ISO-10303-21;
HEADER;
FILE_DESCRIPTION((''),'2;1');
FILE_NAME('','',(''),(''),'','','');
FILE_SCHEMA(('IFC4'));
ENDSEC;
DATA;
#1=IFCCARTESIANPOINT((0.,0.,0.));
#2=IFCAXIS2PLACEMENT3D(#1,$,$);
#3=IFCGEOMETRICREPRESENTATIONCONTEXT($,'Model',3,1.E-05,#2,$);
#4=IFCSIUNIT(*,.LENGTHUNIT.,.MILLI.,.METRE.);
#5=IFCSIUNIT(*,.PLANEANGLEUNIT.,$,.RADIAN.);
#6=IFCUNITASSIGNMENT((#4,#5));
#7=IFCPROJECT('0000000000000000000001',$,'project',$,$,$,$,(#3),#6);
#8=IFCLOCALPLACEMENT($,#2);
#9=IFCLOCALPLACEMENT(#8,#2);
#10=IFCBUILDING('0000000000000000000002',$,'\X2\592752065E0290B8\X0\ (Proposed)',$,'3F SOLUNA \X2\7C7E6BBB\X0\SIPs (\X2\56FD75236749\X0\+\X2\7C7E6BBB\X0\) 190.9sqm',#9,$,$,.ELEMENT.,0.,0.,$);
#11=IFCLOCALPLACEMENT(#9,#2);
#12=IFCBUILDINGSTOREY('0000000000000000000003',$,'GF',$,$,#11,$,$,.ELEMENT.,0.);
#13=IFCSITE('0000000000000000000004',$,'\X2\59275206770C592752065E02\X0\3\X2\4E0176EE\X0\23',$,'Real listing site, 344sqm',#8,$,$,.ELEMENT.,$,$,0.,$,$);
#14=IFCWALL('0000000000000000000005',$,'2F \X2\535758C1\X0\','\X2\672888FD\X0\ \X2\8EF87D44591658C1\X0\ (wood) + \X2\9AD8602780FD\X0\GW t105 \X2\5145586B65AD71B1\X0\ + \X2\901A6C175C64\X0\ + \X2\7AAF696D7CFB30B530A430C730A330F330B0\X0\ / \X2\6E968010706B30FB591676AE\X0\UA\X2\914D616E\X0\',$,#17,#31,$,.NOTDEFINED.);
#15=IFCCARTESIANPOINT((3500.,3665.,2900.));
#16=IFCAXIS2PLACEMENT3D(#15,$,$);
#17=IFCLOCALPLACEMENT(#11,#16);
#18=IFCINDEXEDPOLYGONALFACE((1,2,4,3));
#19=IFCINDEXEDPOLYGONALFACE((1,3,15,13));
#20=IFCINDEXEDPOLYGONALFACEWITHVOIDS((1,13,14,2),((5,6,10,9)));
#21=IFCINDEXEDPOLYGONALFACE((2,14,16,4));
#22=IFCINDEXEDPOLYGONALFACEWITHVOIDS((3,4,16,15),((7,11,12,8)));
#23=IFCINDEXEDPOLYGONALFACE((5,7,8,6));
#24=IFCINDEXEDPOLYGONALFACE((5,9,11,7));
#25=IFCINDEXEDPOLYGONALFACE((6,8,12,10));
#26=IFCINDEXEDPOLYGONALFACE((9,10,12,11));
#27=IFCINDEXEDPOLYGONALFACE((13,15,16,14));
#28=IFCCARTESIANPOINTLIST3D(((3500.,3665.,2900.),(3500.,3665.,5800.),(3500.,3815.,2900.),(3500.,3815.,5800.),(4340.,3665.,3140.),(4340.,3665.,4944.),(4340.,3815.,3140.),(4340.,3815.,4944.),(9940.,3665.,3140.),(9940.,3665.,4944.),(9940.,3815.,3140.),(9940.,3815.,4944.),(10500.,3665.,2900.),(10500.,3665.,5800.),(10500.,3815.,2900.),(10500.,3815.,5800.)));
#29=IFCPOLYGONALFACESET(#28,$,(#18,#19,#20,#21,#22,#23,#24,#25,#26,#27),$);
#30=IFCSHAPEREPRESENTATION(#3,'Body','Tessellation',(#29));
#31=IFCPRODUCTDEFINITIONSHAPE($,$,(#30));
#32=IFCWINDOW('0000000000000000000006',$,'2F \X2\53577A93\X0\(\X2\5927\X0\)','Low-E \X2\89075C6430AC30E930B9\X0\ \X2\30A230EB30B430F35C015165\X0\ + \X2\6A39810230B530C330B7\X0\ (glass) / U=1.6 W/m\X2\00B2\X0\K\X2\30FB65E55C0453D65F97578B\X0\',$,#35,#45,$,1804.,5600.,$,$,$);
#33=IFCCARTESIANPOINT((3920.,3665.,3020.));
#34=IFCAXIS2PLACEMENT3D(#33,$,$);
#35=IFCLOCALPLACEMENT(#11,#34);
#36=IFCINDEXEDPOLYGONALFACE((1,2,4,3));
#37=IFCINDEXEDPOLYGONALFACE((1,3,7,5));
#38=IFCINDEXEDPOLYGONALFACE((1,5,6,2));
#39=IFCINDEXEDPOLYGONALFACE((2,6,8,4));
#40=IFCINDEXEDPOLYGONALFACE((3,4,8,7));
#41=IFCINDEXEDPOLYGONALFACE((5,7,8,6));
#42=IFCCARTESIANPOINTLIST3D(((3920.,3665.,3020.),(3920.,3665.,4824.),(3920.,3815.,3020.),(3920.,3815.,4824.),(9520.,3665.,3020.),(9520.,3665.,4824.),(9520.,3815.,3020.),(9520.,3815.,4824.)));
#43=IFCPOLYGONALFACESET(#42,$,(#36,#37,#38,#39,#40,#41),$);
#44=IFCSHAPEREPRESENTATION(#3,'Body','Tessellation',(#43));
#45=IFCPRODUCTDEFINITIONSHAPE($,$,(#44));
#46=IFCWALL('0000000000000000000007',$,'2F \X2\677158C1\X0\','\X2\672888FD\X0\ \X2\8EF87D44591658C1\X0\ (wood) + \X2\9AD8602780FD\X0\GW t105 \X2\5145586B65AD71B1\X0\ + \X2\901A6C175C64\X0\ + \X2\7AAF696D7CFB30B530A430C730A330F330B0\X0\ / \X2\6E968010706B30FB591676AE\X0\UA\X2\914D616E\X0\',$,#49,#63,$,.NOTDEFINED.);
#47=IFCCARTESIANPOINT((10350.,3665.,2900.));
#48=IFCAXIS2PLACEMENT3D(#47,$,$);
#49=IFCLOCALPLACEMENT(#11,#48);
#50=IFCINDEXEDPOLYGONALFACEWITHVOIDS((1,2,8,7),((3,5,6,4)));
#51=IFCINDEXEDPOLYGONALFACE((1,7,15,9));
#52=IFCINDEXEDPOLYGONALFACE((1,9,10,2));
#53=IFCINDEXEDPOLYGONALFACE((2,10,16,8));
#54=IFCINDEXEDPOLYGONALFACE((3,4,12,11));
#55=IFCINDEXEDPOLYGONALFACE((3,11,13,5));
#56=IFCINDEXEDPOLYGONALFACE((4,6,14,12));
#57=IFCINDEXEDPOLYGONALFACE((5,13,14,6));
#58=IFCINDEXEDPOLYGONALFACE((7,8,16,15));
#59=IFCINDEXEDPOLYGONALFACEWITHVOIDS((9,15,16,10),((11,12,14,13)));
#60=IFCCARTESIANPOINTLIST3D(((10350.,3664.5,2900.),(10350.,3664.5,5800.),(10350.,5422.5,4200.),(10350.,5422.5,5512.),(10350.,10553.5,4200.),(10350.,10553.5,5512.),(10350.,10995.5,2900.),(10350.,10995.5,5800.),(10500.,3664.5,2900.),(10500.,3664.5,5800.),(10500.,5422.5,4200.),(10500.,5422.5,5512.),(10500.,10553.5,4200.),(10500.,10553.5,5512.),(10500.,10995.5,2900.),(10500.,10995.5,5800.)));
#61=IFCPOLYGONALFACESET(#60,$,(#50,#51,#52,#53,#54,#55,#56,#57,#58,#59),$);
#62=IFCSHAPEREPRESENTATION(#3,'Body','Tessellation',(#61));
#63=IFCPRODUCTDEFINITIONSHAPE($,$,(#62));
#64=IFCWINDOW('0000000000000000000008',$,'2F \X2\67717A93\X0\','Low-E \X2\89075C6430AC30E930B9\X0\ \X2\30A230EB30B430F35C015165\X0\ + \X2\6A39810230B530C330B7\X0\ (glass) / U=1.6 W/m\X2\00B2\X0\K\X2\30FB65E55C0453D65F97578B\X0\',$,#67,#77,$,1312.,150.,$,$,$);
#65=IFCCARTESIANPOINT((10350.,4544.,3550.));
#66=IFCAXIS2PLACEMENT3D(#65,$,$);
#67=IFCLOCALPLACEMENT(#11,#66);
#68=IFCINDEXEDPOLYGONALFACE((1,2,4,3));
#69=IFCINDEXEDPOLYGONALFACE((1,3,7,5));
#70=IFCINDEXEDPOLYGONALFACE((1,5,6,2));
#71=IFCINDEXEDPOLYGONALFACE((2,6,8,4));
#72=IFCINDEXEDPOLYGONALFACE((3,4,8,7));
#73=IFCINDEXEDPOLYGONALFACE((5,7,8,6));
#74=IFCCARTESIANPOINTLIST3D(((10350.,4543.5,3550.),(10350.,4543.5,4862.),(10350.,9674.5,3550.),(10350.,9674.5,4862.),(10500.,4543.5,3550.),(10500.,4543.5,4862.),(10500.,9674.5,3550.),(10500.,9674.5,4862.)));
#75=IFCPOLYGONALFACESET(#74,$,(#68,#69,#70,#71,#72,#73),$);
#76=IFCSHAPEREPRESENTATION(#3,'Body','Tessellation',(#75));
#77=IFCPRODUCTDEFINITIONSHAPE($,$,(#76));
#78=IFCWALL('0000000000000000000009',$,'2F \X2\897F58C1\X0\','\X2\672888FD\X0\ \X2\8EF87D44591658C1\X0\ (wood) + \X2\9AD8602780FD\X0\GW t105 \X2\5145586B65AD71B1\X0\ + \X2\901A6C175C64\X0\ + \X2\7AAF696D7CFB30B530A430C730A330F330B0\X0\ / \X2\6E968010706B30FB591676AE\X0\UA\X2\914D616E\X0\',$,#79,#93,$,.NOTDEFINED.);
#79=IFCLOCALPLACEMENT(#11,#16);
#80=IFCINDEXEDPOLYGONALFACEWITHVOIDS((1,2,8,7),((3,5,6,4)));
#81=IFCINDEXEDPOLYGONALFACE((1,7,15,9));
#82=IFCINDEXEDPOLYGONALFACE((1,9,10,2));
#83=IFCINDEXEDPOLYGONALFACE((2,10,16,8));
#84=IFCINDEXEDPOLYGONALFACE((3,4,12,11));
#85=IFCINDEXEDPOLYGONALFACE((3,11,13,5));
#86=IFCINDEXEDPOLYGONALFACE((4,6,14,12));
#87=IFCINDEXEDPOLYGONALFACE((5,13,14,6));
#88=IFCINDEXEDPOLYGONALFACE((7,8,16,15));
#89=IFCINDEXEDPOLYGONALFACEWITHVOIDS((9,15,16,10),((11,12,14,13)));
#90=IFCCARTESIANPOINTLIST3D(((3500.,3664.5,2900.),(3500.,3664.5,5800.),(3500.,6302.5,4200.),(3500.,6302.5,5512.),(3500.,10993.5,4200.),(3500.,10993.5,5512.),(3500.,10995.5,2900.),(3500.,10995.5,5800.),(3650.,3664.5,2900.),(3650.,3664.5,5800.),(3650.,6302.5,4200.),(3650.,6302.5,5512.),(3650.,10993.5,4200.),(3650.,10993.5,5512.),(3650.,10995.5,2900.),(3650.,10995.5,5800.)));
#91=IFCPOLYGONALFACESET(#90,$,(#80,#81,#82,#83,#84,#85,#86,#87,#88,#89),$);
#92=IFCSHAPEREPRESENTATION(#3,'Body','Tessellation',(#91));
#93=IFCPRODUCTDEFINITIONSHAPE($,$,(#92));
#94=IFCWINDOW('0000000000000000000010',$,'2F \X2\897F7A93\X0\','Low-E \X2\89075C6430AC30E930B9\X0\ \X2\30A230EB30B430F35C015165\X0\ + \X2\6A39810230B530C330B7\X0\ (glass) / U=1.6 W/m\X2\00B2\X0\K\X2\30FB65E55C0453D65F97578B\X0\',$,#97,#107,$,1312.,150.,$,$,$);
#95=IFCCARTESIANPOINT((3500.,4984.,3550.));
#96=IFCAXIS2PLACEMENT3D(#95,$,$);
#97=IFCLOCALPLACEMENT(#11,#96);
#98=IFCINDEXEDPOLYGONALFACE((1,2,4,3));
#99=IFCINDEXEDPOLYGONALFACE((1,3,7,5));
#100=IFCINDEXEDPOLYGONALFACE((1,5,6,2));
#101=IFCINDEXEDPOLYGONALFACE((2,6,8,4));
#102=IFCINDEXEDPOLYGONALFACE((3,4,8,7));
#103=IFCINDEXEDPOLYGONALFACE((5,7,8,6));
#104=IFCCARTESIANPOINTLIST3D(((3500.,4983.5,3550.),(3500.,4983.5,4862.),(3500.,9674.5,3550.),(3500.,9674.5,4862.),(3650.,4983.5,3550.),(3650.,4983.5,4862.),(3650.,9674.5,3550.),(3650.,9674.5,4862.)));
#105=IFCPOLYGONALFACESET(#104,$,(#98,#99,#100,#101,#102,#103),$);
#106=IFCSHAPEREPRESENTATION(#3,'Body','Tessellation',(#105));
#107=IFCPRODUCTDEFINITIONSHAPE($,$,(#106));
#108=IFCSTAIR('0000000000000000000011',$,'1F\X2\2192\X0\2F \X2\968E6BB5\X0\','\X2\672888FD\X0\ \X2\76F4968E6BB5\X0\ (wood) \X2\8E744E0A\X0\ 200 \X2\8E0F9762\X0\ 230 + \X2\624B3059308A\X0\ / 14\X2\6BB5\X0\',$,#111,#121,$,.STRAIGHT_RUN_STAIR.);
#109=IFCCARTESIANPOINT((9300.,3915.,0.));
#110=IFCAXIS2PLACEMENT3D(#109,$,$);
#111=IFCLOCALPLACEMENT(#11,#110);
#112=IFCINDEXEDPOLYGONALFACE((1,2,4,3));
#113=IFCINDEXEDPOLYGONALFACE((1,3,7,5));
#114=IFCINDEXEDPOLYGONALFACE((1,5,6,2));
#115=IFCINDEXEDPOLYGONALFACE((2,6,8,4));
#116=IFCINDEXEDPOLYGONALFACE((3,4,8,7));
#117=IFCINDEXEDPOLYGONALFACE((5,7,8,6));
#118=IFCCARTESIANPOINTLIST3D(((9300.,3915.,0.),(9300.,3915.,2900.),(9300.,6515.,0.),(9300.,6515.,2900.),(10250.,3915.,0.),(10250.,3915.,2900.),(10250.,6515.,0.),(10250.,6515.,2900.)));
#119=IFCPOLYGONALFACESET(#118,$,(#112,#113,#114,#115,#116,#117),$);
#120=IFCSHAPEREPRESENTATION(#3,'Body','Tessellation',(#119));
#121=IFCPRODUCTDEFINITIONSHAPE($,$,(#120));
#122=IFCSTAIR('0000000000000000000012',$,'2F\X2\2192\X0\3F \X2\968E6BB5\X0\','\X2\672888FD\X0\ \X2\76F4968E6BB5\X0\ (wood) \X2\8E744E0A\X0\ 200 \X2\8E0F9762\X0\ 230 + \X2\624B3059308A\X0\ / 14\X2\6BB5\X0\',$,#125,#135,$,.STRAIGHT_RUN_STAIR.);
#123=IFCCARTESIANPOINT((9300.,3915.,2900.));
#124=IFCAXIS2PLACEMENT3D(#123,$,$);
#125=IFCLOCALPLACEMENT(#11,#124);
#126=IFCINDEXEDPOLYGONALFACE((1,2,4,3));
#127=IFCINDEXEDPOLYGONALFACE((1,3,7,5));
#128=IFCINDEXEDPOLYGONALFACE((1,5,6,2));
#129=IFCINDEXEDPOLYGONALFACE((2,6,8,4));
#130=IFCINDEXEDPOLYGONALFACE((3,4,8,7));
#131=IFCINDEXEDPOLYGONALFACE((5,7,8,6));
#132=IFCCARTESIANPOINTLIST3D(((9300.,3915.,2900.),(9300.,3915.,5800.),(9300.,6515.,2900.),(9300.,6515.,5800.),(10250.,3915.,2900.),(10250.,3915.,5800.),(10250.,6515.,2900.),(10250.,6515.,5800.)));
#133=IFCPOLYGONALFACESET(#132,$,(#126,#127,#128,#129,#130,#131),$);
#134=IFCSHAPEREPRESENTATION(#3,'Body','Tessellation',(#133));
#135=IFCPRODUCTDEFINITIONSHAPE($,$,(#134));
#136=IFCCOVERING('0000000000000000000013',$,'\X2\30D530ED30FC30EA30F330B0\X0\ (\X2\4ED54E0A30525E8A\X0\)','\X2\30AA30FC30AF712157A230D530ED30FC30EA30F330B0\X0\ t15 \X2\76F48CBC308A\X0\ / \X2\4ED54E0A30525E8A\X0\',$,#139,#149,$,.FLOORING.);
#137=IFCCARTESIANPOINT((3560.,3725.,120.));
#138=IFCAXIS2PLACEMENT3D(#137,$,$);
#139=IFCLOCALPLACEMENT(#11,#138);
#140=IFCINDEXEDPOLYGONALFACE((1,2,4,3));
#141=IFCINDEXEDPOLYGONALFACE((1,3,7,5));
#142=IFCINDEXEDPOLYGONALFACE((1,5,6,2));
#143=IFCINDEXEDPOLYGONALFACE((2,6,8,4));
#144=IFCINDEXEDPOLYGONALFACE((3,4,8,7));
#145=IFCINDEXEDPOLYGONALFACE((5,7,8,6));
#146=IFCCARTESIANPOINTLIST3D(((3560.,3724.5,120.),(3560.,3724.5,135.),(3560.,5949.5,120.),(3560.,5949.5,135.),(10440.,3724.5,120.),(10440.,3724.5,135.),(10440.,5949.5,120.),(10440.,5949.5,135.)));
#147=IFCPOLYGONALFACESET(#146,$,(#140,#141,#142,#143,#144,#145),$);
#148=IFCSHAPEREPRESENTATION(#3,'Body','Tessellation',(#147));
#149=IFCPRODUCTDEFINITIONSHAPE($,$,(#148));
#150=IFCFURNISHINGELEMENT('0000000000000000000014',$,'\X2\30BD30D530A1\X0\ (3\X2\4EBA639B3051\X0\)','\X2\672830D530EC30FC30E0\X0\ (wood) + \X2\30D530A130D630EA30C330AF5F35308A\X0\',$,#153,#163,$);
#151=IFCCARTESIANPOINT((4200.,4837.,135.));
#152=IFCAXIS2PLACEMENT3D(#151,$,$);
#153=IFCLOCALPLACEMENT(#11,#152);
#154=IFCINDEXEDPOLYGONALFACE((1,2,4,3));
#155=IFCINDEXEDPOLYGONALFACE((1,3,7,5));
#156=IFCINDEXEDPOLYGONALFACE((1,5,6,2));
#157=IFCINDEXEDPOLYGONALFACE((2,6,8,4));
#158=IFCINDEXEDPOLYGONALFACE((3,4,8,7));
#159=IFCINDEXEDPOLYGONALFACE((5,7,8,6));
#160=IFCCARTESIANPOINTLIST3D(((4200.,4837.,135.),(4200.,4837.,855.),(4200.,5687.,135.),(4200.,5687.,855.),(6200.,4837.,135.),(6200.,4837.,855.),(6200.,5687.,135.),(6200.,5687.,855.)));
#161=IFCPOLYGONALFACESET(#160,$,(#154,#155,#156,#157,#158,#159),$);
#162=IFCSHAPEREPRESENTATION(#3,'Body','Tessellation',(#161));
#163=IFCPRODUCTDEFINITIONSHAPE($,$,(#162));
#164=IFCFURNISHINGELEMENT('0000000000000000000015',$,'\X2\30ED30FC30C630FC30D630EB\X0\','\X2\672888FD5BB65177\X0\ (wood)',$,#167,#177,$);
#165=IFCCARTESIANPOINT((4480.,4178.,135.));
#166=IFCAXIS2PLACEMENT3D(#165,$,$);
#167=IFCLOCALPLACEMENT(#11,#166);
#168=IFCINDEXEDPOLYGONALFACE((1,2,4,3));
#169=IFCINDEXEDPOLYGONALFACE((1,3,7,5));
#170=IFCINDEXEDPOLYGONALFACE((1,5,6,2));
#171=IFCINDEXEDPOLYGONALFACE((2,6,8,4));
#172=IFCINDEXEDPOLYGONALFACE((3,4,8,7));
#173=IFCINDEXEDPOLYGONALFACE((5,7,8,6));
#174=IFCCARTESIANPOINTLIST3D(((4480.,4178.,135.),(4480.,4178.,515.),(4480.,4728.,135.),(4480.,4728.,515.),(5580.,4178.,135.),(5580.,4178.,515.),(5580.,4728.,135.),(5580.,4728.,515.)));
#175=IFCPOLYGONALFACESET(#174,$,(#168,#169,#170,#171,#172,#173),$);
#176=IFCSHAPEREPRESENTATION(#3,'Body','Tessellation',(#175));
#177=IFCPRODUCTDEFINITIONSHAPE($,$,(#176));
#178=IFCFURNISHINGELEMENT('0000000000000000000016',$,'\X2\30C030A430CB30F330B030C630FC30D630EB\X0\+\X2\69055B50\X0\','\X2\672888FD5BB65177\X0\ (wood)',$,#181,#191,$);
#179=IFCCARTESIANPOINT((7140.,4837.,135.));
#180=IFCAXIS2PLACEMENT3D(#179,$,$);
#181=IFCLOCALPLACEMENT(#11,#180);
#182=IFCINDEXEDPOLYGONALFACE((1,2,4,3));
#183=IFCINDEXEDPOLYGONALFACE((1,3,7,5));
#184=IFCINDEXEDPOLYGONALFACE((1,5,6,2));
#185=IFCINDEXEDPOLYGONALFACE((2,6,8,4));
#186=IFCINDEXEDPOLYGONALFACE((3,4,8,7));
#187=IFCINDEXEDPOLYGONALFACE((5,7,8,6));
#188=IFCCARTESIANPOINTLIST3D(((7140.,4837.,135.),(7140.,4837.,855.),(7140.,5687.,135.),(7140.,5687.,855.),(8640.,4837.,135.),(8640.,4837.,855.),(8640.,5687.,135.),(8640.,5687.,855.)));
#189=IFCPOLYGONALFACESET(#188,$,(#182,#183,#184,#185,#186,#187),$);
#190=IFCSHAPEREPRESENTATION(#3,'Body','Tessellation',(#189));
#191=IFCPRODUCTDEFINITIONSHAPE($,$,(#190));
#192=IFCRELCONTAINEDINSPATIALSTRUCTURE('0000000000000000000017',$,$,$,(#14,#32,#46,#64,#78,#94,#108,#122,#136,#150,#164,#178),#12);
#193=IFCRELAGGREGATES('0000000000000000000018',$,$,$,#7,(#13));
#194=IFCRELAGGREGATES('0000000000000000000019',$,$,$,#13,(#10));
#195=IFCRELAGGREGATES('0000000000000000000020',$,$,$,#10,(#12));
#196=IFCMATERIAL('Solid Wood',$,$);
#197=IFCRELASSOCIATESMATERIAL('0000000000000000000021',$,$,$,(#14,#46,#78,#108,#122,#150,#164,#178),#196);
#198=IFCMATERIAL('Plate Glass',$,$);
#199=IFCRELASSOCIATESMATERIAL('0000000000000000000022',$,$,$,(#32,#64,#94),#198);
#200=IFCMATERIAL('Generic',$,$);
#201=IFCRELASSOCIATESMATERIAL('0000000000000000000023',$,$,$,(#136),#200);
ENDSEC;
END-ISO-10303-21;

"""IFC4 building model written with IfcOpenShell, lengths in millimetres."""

from ifc_helpers import new_model, si_unit, frame, frame_2d, origin, place, context, project, spatial, rectangle, extrude, material, element, fill, save


model = new_model("IFC4")

# Units and contexts
model_context = context("Model", 3, precision=1e-05, world=origin())
ifc_project = project(units=[si_unit("LENGTHUNIT", "METRE", prefix="MILLI"), si_unit("PLANEANGLEUNIT", "RADIAN")], contexts=[model_context])

# Site, building, storey
site_placement = place(None, origin())
site = spatial("IfcSite", under=ifc_project, at=site_placement, Name="大分県大分市3丁目23", ObjectType="Real listing site, 344sqm", CompositionType="ELEMENT", RefElevation=0.0)
building_placement = place(site_placement, origin())
building = spatial("IfcBuilding", under=site, at=building_placement, Name="大分市邸 (Proposed)", ObjectType="3F SOLUNA 籾殻SIPs (国産杉+籾殻) 190.9sqm", CompositionType="ELEMENT", ElevationOfRefHeight=0.0, ElevationOfTerrain=0.0)
storey_placement = place(building_placement, origin())
storey = spatial("IfcBuildingStorey", under=building, at=storey_placement, Name="GF", CompositionType="ELEMENT", Elevation=0.0)

# Shared definitions
ifc_material_1 = material(Name="Solid Wood")

# Shared definitions
ifc_material_2 = material(Name="Plate Glass")

# Walls, openings, windows
wall_1_placement = place(storey_placement, frame((3500.0, 3665.0, 2900.0)))
wall_1 = element("IfcWall", 1, at=wall_1_placement, inside=storey, material=ifc_material_1, Name="2F 南壁", Description="木製 軸組外壁 (wood) + 高性能GW t105 充填断熱 + 通気層 + 窯業系サイディング / 準耐火・外皮UA配慮", PredefinedType="NOTDEFINED", context=model_context, shape_type="SweptSolid", body=[
    extrude(rectangle(XDim=7000.0, YDim=150.0, at=frame_2d((3500.0, 75.0))), frame((3500.0, 3665.0, 2900.0)), (0.0, 0.0, 1.0), 2900.0),
])
opening_1_placement = place(storey_placement, frame((3920.0, 3665.0, 3020.0)))
opening_1 = element("IfcOpeningElement", 2, at=opening_1_placement, cuts=wall_1, PredefinedType="NOTDEFINED", context=model_context, shape_type="SweptSolid", body=[
    extrude(rectangle(XDim=5600.0, YDim=150.0, at=frame_2d((2800.0, 75.0))), frame((3920.0, 3665.0, 3020.0)), (0.0, 0.0, 1.0), 1804.0),
])
window_1_placement = place(storey_placement, frame((3920.0, 3665.0, 3020.0)))
window_1 = element("IfcWindow", 3, at=window_1_placement, inside=storey, material=ifc_material_2, Name="2F 南窓(大)", Description="Low-E 複層ガラス アルゴン封入 + 樹脂サッシ (glass) / U=1.6 W/m²K・日射取得型", OverallHeight=1804.0, OverallWidth=5600.0, context=model_context, shape_type="SweptSolid", body=[
    extrude(rectangle(XDim=5600.0, YDim=150.0, at=frame_2d((2800.0, 75.0))), frame((3920.0, 3665.0, 3020.0)), (0.0, 0.0, 1.0), 1804.0),
])
fill(opening_1, window_1)
wall_2_placement = place(storey_placement, frame((10350.0, 3665.0, 2900.0)))
wall_2 = element("IfcWall", 4, at=wall_2_placement, inside=storey, material=ifc_material_1, Name="2F 東壁", Description="木製 軸組外壁 (wood) + 高性能GW t105 充填断熱 + 通気層 + 窯業系サイディング / 準耐火・外皮UA配慮", PredefinedType="NOTDEFINED", context=model_context, shape_type="SweptSolid", body=[
    extrude(rectangle(XDim=150.0, YDim=7331.0, at=frame_2d((75.0, 3665.0))), frame((10350.0, 3665.0, 2900.0)), (0.0, 0.0, 1.0), 2900.0),
])
opening_2_placement = place(storey_placement, frame((10350.0, 4544.0, 3550.0)))
opening_2 = element("IfcOpeningElement", 5, at=opening_2_placement, cuts=wall_2, PredefinedType="NOTDEFINED", context=model_context, shape_type="SweptSolid", body=[
    extrude(rectangle(XDim=150.0, YDim=5131.0, at=frame_2d((75.0, 2565.0))), frame((10350.0, 4544.0, 3550.0)), (0.0, 0.0, 1.0), 1312.0),
])
window_2_placement = place(storey_placement, frame((10350.0, 4544.0, 3550.0)))
window_2 = element("IfcWindow", 6, at=window_2_placement, inside=storey, material=ifc_material_2, Name="2F 東窓", Description="Low-E 複層ガラス アルゴン封入 + 樹脂サッシ (glass) / U=1.6 W/m²K・日射取得型", OverallHeight=1312.0, OverallWidth=150.0, context=model_context, shape_type="SweptSolid", body=[
    extrude(rectangle(XDim=150.0, YDim=5131.0, at=frame_2d((75.0, 2565.0))), frame((10350.0, 4544.0, 3550.0)), (0.0, 0.0, 1.0), 1312.0),
])
fill(opening_2, window_2)
wall_3_placement = place(storey_placement, frame((3500.0, 3665.0, 2900.0)))
wall_3 = element("IfcWall", 7, at=wall_3_placement, inside=storey, material=ifc_material_1, Name="2F 西壁", Description="木製 軸組外壁 (wood) + 高性能GW t105 充填断熱 + 通気層 + 窯業系サイディング / 準耐火・外皮UA配慮", PredefinedType="NOTDEFINED", context=model_context, shape_type="SweptSolid", body=[
    extrude(rectangle(XDim=150.0, YDim=7331.0, at=frame_2d((75.0, 3665.0))), frame((3500.0, 3665.0, 2900.0)), (0.0, 0.0, 1.0), 2900.0),
])
opening_3_placement = place(storey_placement, frame((3500.0, 4984.0, 3550.0)))
opening_3 = element("IfcOpeningElement", 8, at=opening_3_placement, cuts=wall_3, PredefinedType="NOTDEFINED", context=model_context, shape_type="SweptSolid", body=[
    extrude(rectangle(XDim=150.0, YDim=4691.0, at=frame_2d((75.0, 2345.0))), frame((3500.0, 4984.0, 3550.0)), (0.0, 0.0, 1.0), 1312.0),
])
window_3_placement = place(storey_placement, frame((3500.0, 4984.0, 3550.0)))
window_3 = element("IfcWindow", 9, at=window_3_placement, inside=storey, material=ifc_material_2, Name="2F 西窓", Description="Low-E 複層ガラス アルゴン封入 + 樹脂サッシ (glass) / U=1.6 W/m²K・日射取得型", OverallHeight=1312.0, OverallWidth=150.0, context=model_context, shape_type="SweptSolid", body=[
    extrude(rectangle(XDim=150.0, YDim=4691.0, at=frame_2d((75.0, 2345.0))), frame((3500.0, 4984.0, 3550.0)), (0.0, 0.0, 1.0), 1312.0),
])
fill(opening_3, window_3)

# Stairs
stair_1_placement = place(storey_placement, frame((9300.0, 3915.0, 0.0)))
element("IfcStair", 10, at=stair_1_placement, inside=storey, material=ifc_material_1, Name="1F→2F 階段", Description="木製 直階段 (wood) 蹴上 200 踏面 230 + 手すり / 14段", PredefinedType="STRAIGHT_RUN_STAIR", context=model_context, shape_type="SweptSolid", body=[
    extrude(rectangle(XDim=950.0, YDim=2600.0, at=frame_2d((475.0, 1300.0))), frame((9300.0, 3915.0, 0.0)), (0.0, 0.0, 1.0), 2900.0),
])
stair_2_placement = place(storey_placement, frame((9300.0, 3915.0, 2900.0)))
element("IfcStair", 11, at=stair_2_placement, inside=storey, material=ifc_material_1, Name="2F→3F 階段", Description="木製 直階段 (wood) 蹴上 200 踏面 230 + 手すり / 14段", PredefinedType="STRAIGHT_RUN_STAIR", context=model_context, shape_type="SweptSolid", body=[
    extrude(rectangle(XDim=950.0, YDim=2600.0, at=frame_2d((475.0, 1300.0))), frame((9300.0, 3915.0, 2900.0)), (0.0, 0.0, 1.0), 2900.0),
])

# Covering
ifc_material_3 = material(Name="Generic")
covering_placement = place(storey_placement, frame((3560.0, 3725.0, 120.0)))
element("IfcCovering", 12, at=covering_placement, inside=storey, material=ifc_material_3, Name="フローリング (仕上げ床)", Description="オーク無垢フローリング t15 直貼り / 仕上げ床", PredefinedType="FLOORING", context=model_context, shape_type="SweptSolid", body=[
    extrude(rectangle(XDim=6880.0, YDim=2225.0, at=frame_2d((3440.0, 1112.0))), frame((3560.0, 3725.0, 120.0)), (0.0, 0.0, 1.0), 15.0),
])

# Furnishing elements
furnishing_1_placement = place(storey_placement, frame((4200.0, 4837.0, 135.0)))
element("IfcFurnishingElement", 13, at=furnishing_1_placement, inside=storey, material=ifc_material_1, Name="ソファ (3人掛け)", Description="木フレーム (wood) + ファブリック張り", context=model_context, shape_type="SweptSolid", body=[
    extrude(rectangle(XDim=2000.0, YDim=850.0, at=frame_2d((1000.0, 425.0))), frame((4200.0, 4837.0, 135.0)), (0.0, 0.0, 1.0), 720.0),
])
furnishing_2_placement = place(storey_placement, frame((4480.0, 4178.0, 135.0)))
element("IfcFurnishingElement", 14, at=furnishing_2_placement, inside=storey, material=ifc_material_1, Name="ローテーブル", Description="木製家具 (wood)", context=model_context, shape_type="SweptSolid", body=[
    extrude(rectangle(XDim=1100.0, YDim=550.0, at=frame_2d((550.0, 275.0))), frame((4480.0, 4178.0, 135.0)), (0.0, 0.0, 1.0), 380.0),
])
furnishing_3_placement = place(storey_placement, frame((7140.0, 4837.0, 135.0)))
element("IfcFurnishingElement", 15, at=furnishing_3_placement, inside=storey, material=ifc_material_1, Name="ダイニングテーブル+椅子", Description="木製家具 (wood)", context=model_context, shape_type="SweptSolid", body=[
    extrude(rectangle(XDim=1500.0, YDim=850.0, at=frame_2d((750.0, 425.0))), frame((7140.0, 4837.0, 135.0)), (0.0, 0.0, 1.0), 720.0),
])

save(model, "model.ifc")
